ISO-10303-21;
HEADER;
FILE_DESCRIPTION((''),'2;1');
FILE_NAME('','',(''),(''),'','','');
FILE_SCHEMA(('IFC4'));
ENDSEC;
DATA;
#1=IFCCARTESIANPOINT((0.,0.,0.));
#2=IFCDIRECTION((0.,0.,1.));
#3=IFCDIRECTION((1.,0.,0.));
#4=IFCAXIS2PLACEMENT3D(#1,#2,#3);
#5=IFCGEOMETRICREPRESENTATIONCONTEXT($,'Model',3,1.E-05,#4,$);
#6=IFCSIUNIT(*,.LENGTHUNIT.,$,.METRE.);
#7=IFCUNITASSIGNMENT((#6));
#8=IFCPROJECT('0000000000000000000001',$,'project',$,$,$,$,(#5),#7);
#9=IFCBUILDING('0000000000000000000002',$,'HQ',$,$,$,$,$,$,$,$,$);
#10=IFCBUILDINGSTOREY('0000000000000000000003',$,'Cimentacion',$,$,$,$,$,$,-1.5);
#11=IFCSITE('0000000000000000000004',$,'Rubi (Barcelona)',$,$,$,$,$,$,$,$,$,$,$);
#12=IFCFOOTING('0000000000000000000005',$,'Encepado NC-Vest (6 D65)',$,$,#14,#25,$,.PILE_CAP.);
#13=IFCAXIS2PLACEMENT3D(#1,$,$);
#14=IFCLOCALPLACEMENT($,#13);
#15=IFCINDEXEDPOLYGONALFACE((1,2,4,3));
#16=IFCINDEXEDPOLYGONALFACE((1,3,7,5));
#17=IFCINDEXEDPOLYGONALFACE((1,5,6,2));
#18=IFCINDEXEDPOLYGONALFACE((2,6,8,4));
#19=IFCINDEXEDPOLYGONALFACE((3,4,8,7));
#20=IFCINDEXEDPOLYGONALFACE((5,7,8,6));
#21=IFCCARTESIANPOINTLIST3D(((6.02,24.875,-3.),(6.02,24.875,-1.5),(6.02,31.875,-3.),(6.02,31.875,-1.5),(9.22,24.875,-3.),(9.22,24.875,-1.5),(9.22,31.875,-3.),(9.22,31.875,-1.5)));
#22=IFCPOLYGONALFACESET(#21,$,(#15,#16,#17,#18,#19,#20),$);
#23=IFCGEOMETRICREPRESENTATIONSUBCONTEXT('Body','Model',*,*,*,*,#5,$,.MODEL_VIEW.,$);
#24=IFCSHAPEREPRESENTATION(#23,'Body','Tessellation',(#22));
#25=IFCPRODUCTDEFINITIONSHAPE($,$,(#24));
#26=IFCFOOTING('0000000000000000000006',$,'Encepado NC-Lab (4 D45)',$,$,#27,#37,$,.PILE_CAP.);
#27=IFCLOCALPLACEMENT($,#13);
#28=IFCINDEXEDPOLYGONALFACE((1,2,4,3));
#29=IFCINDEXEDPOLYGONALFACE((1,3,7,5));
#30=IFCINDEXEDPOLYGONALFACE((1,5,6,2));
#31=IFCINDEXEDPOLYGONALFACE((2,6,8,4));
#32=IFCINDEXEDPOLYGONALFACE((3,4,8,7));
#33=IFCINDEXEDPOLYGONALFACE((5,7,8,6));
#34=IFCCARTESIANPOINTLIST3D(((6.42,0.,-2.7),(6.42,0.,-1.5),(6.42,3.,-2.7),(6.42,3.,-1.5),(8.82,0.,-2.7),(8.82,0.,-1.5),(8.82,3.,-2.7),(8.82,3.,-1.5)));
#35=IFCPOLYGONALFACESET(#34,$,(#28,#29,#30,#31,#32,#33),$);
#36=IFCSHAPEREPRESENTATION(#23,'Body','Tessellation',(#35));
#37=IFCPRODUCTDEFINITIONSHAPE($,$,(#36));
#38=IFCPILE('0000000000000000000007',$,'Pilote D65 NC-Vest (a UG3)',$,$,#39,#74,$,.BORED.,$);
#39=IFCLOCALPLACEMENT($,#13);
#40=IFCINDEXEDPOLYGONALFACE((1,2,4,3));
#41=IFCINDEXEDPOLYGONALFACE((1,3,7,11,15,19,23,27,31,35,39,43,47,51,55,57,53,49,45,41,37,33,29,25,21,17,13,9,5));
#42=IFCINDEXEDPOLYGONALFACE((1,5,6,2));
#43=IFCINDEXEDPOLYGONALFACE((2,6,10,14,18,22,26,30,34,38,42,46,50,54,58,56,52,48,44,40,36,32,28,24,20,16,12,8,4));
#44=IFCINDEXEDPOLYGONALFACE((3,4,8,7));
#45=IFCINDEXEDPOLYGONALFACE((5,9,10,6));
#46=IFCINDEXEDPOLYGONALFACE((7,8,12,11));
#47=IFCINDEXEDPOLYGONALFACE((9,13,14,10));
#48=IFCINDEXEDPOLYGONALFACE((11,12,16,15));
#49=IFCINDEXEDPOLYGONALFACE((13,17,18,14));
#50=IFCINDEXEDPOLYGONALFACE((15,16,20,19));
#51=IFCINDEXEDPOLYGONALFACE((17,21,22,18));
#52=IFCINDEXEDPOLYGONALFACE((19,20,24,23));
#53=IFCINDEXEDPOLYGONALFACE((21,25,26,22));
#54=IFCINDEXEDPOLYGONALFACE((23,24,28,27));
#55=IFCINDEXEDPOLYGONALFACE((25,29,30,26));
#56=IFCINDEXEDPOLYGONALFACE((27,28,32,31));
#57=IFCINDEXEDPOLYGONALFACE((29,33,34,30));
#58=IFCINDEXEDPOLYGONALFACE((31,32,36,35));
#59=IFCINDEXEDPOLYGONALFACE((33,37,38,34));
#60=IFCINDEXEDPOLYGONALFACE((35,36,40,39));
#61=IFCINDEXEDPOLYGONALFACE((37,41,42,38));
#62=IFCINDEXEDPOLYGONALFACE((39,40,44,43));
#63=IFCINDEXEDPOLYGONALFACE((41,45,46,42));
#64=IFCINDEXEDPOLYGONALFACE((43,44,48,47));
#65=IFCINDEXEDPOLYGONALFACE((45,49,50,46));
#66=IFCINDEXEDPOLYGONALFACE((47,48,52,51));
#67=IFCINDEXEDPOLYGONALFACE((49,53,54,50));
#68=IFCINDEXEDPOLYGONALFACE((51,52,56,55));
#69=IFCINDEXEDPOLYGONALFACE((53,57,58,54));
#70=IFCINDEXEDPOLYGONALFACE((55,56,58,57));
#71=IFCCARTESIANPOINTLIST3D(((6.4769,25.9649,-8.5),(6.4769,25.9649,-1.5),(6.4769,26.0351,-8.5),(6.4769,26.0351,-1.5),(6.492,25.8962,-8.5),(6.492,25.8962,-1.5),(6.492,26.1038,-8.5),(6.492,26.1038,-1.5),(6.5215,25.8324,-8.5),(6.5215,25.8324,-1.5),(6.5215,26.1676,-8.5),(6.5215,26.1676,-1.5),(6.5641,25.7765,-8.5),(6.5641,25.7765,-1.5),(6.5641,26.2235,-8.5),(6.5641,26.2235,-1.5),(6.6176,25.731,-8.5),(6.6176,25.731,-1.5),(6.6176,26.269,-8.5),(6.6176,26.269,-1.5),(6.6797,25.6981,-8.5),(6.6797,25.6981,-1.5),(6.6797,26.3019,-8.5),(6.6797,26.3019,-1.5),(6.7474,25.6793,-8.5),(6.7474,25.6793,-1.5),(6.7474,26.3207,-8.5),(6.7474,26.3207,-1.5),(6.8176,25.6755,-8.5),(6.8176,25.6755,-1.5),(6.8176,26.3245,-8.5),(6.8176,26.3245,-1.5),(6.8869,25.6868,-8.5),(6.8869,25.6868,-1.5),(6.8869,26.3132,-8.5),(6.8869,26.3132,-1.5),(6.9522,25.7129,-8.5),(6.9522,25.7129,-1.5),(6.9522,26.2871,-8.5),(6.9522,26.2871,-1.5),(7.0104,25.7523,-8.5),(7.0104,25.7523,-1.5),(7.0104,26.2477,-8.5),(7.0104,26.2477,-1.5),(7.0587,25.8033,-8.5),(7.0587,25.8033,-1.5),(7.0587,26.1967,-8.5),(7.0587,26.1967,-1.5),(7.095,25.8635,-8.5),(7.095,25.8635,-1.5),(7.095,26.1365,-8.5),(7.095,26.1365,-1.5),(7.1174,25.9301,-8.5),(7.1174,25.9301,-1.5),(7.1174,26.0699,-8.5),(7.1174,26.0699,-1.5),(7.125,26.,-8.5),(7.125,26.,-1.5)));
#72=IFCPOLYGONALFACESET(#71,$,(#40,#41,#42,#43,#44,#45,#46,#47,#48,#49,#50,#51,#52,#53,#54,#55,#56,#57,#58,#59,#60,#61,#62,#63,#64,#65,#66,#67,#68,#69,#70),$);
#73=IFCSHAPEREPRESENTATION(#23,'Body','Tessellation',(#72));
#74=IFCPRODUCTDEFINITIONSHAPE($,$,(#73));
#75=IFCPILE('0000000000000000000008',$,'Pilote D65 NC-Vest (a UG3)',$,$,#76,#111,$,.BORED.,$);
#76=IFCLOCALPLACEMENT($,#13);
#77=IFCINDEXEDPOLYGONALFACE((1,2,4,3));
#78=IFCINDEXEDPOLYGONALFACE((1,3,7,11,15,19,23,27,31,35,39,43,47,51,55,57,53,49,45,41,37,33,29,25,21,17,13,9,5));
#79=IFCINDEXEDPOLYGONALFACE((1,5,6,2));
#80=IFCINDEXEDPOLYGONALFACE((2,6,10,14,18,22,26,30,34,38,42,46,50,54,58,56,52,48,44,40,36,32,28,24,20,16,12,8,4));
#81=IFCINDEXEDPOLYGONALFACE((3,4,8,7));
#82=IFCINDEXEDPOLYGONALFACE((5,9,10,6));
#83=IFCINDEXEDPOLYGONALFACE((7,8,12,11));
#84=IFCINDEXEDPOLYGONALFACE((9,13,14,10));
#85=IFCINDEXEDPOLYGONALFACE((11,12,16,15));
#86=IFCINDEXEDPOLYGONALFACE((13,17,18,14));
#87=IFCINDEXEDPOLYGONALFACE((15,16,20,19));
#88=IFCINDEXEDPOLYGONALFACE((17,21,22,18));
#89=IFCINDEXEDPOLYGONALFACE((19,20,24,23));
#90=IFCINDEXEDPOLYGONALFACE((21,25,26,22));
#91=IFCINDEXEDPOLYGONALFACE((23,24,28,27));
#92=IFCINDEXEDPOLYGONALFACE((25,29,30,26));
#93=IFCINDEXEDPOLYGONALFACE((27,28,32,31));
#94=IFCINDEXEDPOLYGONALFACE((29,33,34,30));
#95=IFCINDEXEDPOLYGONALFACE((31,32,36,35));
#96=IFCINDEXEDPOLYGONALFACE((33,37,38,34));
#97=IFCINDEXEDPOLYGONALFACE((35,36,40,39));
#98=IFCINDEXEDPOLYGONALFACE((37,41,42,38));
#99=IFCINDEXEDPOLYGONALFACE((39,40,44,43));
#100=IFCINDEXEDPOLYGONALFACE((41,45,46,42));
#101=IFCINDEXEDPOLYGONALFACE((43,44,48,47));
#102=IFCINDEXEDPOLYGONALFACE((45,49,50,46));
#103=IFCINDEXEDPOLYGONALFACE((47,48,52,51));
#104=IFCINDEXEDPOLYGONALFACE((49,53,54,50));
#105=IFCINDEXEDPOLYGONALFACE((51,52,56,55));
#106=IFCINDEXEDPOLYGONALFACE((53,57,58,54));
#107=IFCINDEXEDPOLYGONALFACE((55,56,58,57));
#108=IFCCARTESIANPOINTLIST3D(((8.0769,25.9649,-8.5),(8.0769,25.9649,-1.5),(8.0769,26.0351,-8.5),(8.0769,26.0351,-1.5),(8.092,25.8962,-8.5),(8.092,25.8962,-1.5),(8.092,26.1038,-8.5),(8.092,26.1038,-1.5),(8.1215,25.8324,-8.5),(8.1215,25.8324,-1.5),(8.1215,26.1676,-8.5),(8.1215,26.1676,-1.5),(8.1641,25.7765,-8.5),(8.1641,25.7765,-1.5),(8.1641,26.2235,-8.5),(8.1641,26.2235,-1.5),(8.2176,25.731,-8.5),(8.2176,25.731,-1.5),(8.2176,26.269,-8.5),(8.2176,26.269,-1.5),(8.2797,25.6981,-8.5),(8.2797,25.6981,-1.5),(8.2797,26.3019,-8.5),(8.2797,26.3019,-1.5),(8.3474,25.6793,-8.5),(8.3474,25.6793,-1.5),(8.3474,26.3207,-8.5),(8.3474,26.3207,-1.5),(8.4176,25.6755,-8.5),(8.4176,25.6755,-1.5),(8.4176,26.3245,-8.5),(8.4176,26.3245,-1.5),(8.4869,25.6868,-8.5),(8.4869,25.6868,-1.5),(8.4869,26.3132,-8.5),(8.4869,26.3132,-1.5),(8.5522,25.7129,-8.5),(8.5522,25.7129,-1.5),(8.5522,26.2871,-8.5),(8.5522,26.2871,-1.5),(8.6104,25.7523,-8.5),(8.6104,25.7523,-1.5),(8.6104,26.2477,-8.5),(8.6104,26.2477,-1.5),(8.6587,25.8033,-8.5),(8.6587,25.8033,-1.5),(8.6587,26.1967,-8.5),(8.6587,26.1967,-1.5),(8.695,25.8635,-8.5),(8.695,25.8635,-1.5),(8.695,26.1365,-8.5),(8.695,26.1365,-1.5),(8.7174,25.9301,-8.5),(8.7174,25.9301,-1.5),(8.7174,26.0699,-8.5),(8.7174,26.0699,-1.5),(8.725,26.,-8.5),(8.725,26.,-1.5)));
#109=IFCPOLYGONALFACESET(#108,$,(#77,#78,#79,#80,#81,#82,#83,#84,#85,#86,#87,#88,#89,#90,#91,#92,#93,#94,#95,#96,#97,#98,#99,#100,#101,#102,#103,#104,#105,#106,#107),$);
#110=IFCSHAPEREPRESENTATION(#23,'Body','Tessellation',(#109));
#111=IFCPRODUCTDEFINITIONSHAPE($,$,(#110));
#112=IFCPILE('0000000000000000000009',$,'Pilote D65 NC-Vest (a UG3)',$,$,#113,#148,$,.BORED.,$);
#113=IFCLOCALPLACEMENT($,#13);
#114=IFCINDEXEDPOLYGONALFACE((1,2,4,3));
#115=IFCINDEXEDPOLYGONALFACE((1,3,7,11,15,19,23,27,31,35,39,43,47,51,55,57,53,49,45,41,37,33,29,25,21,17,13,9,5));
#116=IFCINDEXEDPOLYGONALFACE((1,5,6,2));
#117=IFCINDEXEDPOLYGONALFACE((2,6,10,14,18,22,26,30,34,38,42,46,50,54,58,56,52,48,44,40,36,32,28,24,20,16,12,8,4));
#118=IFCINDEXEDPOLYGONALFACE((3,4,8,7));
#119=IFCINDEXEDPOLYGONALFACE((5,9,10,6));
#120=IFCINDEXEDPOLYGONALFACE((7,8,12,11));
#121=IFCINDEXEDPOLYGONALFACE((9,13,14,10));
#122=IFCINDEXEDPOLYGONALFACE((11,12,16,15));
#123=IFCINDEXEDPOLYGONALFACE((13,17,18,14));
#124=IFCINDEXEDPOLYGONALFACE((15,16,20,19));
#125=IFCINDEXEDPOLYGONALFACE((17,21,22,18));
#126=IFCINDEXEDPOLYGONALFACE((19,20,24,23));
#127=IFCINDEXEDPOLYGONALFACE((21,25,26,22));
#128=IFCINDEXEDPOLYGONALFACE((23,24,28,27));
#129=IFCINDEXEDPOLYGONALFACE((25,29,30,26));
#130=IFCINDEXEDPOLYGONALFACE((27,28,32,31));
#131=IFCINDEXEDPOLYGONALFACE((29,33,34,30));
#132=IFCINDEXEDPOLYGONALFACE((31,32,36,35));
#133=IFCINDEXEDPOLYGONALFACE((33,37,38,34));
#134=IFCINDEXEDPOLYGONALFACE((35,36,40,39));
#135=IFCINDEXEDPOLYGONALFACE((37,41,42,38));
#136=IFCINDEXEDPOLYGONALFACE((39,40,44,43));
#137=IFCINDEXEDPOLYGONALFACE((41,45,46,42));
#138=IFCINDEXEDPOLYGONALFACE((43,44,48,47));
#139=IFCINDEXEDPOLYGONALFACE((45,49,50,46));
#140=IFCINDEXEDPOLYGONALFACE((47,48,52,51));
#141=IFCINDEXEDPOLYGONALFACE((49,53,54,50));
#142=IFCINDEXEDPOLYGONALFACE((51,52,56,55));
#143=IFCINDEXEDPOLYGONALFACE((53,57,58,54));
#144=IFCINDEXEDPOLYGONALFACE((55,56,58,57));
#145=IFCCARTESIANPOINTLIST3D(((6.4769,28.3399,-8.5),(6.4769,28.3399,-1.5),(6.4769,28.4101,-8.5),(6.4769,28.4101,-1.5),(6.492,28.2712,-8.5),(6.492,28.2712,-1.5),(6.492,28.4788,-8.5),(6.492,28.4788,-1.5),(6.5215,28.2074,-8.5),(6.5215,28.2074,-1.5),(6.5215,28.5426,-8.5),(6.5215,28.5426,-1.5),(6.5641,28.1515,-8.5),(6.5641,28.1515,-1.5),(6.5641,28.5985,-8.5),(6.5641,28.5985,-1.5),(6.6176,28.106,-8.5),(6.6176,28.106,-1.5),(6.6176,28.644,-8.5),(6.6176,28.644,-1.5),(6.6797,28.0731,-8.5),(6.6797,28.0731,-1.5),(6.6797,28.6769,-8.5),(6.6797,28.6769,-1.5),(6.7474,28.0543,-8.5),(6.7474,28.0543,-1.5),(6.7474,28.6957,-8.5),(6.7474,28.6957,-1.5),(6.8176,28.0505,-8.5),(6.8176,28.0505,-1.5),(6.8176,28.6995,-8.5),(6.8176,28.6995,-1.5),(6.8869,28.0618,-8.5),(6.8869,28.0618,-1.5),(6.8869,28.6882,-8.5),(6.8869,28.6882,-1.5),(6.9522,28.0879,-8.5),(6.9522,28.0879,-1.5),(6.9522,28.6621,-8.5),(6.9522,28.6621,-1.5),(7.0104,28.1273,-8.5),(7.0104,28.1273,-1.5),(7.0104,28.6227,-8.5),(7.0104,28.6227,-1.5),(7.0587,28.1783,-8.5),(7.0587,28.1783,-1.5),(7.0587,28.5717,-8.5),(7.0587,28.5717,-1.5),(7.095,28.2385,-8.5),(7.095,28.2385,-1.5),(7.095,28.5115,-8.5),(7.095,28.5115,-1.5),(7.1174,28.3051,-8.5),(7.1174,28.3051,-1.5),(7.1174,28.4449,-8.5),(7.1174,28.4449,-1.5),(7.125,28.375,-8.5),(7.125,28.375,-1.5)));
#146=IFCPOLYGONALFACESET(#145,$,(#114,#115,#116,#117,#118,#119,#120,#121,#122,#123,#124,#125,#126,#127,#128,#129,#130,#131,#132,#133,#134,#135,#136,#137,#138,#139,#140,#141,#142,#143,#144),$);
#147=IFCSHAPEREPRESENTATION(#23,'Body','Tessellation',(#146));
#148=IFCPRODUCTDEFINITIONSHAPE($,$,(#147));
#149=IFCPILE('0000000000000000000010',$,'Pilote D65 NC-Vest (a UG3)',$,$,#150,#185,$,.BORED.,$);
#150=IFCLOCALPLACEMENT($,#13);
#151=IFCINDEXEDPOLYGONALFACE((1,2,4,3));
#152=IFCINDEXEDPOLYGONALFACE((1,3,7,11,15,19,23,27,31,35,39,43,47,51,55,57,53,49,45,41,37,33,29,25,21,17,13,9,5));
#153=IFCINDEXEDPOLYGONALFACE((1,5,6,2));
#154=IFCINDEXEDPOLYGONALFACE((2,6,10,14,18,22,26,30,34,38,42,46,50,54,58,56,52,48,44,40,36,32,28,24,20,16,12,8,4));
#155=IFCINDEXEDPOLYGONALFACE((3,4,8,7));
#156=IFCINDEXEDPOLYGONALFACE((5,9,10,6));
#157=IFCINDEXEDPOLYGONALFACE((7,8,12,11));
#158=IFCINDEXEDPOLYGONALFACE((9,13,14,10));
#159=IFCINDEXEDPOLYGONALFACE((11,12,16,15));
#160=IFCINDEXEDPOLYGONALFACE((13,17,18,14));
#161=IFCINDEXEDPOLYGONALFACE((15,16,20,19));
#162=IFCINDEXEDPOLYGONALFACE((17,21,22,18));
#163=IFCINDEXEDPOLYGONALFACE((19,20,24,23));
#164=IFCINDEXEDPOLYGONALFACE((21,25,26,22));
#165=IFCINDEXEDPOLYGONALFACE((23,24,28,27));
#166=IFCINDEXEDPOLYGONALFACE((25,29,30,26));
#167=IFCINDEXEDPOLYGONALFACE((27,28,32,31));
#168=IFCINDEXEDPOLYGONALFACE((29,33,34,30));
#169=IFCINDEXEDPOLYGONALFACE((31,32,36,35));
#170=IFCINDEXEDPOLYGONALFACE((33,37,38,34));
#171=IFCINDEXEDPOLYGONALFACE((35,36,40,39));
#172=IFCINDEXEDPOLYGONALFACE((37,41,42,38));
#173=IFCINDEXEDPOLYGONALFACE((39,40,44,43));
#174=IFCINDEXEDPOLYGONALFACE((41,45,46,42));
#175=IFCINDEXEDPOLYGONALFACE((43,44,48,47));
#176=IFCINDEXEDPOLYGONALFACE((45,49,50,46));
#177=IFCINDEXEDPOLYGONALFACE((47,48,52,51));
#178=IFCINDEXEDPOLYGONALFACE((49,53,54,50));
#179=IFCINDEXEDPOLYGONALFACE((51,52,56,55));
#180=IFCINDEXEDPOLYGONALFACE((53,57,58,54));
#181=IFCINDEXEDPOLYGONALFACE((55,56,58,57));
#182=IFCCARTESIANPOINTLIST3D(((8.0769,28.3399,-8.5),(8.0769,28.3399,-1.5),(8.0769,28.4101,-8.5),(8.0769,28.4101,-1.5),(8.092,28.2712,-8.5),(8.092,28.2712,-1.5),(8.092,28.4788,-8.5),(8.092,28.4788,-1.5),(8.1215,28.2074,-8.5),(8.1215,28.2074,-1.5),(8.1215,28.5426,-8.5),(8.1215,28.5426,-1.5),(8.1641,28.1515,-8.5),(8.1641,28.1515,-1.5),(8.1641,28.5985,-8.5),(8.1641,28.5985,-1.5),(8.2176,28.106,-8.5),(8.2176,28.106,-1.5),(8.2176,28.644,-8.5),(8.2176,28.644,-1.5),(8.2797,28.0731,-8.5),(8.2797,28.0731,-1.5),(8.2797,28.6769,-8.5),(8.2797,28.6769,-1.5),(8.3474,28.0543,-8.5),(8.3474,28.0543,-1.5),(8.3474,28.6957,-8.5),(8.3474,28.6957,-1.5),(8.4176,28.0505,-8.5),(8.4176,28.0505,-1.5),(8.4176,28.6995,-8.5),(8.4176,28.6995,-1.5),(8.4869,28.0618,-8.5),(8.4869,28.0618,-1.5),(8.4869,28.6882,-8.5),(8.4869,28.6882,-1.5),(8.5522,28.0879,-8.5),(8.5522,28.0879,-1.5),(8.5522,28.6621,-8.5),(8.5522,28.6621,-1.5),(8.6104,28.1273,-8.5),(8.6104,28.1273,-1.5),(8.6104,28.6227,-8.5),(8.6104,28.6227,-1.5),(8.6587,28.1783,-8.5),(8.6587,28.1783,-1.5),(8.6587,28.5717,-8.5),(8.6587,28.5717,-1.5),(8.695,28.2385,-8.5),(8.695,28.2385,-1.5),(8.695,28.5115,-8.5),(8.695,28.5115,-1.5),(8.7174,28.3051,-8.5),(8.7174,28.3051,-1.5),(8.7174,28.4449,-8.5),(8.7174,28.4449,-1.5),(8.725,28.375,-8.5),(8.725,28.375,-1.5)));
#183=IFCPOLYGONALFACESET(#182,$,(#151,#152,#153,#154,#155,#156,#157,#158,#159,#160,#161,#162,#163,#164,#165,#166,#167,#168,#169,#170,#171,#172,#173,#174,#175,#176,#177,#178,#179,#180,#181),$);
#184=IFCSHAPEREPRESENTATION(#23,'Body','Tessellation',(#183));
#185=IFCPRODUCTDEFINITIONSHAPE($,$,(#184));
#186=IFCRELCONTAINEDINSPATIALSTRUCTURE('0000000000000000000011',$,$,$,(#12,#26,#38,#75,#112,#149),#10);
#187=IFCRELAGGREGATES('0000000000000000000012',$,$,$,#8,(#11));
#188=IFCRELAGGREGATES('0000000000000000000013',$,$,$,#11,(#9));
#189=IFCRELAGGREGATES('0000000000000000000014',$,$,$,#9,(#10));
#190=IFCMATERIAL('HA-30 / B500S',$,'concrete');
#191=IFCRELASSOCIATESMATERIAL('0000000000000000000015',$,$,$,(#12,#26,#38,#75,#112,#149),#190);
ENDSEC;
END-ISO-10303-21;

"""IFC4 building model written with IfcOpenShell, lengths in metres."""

from ifc_helpers import new_model, si_unit, frame, origin_with_axes, place, context, subcontext, project, spatial, polyline, circle, outline, extrude, material, element, save


model = new_model("IFC4")

# Units and contexts
model_context = context("Model", 3, precision=1e-05, world=origin_with_axes())
body_context = subcontext(model_context, "Body", "Model", "MODEL_VIEW")
ifc_project = project(units=[si_unit("LENGTHUNIT", "METRE")], contexts=[model_context])

# Site, building, storey
site = spatial("IfcSite", under=ifc_project, Name="Rubi (Barcelona)")
building = spatial("IfcBuilding", under=site, Name="HQ")
storey = spatial("IfcBuildingStorey", under=building, Name="Cimentacion", Elevation=-1.5)

# Footings
ifc_material = material(Name="HA-30 / B500S", Category="concrete")
footing_1_placement = place(None, origin_with_axes())
element("IfcFooting", 1, at=footing_1_placement, inside=storey, material=ifc_material, Name="Encepado NC-Vest (6 D65)", PredefinedType="PILE_CAP", context=body_context, shape_type="SweptSolid", body=[
    extrude(outline(polyline([(6.02, 24.875, 0.0), (9.22, 24.875, 0.0), (9.22, 31.875, 0.0), (6.02, 31.875, 0.0), (6.02, 24.875, 0.0)])), frame((0.0, 0.0, -3.0)), (0.0, 0.0, 1.0), 1.5),
])
footing_2_placement = place(None, origin_with_axes())
element("IfcFooting", 2, at=footing_2_placement, inside=storey, material=ifc_material, Name="Encepado NC-Lab (4 D45)", PredefinedType="PILE_CAP", context=body_context, shape_type="SweptSolid", body=[
    extrude(outline(polyline([(6.42, 0.0, 0.0), (8.82, 0.0, 0.0), (8.82, 3.0, 0.0), (6.42, 3.0, 0.0), (6.42, 0.0, 0.0)])), frame((0.0, 0.0, -2.7)), (0.0, 0.0, 1.0), 1.2),
])

# Piles
pile_1_placement = place(None, origin_with_axes())
element("IfcPile", 3, at=pile_1_placement, inside=storey, material=ifc_material, Name="Pilote D65 NC-Vest (a UG3)", PredefinedType="BORED", context=body_context, shape_type="SweptSolid", body=[
    extrude(circle(Radius=0.325), frame((6.8, 26.0, -8.5)), (0.0, 0.0, 1.0), 7.0),
])
pile_2_placement = place(None, origin_with_axes())
element("IfcPile", 4, at=pile_2_placement, inside=storey, material=ifc_material, Name="Pilote D65 NC-Vest (a UG3)", PredefinedType="BORED", context=body_context, shape_type="SweptSolid", body=[
    extrude(circle(Radius=0.325), frame((8.4, 26.0, -8.5)), (0.0, 0.0, 1.0), 7.0),
])
pile_3_placement = place(None, origin_with_axes())
element("IfcPile", 5, at=pile_3_placement, inside=storey, material=ifc_material, Name="Pilote D65 NC-Vest (a UG3)", PredefinedType="BORED", context=body_context, shape_type="SweptSolid", body=[
    extrude(circle(Radius=0.325), frame((6.8, 28.375, -8.5)), (0.0, 0.0, 1.0), 7.0),
])
pile_4_placement = place(None, origin_with_axes())
element("IfcPile", 6, at=pile_4_placement, inside=storey, material=ifc_material, Name="Pilote D65 NC-Vest (a UG3)", PredefinedType="BORED", context=body_context, shape_type="SweptSolid", body=[
    extrude(circle(Radius=0.325), frame((8.4, 28.375, -8.5)), (0.0, 0.0, 1.0), 7.0),
])

save(model, "model.ifc")
